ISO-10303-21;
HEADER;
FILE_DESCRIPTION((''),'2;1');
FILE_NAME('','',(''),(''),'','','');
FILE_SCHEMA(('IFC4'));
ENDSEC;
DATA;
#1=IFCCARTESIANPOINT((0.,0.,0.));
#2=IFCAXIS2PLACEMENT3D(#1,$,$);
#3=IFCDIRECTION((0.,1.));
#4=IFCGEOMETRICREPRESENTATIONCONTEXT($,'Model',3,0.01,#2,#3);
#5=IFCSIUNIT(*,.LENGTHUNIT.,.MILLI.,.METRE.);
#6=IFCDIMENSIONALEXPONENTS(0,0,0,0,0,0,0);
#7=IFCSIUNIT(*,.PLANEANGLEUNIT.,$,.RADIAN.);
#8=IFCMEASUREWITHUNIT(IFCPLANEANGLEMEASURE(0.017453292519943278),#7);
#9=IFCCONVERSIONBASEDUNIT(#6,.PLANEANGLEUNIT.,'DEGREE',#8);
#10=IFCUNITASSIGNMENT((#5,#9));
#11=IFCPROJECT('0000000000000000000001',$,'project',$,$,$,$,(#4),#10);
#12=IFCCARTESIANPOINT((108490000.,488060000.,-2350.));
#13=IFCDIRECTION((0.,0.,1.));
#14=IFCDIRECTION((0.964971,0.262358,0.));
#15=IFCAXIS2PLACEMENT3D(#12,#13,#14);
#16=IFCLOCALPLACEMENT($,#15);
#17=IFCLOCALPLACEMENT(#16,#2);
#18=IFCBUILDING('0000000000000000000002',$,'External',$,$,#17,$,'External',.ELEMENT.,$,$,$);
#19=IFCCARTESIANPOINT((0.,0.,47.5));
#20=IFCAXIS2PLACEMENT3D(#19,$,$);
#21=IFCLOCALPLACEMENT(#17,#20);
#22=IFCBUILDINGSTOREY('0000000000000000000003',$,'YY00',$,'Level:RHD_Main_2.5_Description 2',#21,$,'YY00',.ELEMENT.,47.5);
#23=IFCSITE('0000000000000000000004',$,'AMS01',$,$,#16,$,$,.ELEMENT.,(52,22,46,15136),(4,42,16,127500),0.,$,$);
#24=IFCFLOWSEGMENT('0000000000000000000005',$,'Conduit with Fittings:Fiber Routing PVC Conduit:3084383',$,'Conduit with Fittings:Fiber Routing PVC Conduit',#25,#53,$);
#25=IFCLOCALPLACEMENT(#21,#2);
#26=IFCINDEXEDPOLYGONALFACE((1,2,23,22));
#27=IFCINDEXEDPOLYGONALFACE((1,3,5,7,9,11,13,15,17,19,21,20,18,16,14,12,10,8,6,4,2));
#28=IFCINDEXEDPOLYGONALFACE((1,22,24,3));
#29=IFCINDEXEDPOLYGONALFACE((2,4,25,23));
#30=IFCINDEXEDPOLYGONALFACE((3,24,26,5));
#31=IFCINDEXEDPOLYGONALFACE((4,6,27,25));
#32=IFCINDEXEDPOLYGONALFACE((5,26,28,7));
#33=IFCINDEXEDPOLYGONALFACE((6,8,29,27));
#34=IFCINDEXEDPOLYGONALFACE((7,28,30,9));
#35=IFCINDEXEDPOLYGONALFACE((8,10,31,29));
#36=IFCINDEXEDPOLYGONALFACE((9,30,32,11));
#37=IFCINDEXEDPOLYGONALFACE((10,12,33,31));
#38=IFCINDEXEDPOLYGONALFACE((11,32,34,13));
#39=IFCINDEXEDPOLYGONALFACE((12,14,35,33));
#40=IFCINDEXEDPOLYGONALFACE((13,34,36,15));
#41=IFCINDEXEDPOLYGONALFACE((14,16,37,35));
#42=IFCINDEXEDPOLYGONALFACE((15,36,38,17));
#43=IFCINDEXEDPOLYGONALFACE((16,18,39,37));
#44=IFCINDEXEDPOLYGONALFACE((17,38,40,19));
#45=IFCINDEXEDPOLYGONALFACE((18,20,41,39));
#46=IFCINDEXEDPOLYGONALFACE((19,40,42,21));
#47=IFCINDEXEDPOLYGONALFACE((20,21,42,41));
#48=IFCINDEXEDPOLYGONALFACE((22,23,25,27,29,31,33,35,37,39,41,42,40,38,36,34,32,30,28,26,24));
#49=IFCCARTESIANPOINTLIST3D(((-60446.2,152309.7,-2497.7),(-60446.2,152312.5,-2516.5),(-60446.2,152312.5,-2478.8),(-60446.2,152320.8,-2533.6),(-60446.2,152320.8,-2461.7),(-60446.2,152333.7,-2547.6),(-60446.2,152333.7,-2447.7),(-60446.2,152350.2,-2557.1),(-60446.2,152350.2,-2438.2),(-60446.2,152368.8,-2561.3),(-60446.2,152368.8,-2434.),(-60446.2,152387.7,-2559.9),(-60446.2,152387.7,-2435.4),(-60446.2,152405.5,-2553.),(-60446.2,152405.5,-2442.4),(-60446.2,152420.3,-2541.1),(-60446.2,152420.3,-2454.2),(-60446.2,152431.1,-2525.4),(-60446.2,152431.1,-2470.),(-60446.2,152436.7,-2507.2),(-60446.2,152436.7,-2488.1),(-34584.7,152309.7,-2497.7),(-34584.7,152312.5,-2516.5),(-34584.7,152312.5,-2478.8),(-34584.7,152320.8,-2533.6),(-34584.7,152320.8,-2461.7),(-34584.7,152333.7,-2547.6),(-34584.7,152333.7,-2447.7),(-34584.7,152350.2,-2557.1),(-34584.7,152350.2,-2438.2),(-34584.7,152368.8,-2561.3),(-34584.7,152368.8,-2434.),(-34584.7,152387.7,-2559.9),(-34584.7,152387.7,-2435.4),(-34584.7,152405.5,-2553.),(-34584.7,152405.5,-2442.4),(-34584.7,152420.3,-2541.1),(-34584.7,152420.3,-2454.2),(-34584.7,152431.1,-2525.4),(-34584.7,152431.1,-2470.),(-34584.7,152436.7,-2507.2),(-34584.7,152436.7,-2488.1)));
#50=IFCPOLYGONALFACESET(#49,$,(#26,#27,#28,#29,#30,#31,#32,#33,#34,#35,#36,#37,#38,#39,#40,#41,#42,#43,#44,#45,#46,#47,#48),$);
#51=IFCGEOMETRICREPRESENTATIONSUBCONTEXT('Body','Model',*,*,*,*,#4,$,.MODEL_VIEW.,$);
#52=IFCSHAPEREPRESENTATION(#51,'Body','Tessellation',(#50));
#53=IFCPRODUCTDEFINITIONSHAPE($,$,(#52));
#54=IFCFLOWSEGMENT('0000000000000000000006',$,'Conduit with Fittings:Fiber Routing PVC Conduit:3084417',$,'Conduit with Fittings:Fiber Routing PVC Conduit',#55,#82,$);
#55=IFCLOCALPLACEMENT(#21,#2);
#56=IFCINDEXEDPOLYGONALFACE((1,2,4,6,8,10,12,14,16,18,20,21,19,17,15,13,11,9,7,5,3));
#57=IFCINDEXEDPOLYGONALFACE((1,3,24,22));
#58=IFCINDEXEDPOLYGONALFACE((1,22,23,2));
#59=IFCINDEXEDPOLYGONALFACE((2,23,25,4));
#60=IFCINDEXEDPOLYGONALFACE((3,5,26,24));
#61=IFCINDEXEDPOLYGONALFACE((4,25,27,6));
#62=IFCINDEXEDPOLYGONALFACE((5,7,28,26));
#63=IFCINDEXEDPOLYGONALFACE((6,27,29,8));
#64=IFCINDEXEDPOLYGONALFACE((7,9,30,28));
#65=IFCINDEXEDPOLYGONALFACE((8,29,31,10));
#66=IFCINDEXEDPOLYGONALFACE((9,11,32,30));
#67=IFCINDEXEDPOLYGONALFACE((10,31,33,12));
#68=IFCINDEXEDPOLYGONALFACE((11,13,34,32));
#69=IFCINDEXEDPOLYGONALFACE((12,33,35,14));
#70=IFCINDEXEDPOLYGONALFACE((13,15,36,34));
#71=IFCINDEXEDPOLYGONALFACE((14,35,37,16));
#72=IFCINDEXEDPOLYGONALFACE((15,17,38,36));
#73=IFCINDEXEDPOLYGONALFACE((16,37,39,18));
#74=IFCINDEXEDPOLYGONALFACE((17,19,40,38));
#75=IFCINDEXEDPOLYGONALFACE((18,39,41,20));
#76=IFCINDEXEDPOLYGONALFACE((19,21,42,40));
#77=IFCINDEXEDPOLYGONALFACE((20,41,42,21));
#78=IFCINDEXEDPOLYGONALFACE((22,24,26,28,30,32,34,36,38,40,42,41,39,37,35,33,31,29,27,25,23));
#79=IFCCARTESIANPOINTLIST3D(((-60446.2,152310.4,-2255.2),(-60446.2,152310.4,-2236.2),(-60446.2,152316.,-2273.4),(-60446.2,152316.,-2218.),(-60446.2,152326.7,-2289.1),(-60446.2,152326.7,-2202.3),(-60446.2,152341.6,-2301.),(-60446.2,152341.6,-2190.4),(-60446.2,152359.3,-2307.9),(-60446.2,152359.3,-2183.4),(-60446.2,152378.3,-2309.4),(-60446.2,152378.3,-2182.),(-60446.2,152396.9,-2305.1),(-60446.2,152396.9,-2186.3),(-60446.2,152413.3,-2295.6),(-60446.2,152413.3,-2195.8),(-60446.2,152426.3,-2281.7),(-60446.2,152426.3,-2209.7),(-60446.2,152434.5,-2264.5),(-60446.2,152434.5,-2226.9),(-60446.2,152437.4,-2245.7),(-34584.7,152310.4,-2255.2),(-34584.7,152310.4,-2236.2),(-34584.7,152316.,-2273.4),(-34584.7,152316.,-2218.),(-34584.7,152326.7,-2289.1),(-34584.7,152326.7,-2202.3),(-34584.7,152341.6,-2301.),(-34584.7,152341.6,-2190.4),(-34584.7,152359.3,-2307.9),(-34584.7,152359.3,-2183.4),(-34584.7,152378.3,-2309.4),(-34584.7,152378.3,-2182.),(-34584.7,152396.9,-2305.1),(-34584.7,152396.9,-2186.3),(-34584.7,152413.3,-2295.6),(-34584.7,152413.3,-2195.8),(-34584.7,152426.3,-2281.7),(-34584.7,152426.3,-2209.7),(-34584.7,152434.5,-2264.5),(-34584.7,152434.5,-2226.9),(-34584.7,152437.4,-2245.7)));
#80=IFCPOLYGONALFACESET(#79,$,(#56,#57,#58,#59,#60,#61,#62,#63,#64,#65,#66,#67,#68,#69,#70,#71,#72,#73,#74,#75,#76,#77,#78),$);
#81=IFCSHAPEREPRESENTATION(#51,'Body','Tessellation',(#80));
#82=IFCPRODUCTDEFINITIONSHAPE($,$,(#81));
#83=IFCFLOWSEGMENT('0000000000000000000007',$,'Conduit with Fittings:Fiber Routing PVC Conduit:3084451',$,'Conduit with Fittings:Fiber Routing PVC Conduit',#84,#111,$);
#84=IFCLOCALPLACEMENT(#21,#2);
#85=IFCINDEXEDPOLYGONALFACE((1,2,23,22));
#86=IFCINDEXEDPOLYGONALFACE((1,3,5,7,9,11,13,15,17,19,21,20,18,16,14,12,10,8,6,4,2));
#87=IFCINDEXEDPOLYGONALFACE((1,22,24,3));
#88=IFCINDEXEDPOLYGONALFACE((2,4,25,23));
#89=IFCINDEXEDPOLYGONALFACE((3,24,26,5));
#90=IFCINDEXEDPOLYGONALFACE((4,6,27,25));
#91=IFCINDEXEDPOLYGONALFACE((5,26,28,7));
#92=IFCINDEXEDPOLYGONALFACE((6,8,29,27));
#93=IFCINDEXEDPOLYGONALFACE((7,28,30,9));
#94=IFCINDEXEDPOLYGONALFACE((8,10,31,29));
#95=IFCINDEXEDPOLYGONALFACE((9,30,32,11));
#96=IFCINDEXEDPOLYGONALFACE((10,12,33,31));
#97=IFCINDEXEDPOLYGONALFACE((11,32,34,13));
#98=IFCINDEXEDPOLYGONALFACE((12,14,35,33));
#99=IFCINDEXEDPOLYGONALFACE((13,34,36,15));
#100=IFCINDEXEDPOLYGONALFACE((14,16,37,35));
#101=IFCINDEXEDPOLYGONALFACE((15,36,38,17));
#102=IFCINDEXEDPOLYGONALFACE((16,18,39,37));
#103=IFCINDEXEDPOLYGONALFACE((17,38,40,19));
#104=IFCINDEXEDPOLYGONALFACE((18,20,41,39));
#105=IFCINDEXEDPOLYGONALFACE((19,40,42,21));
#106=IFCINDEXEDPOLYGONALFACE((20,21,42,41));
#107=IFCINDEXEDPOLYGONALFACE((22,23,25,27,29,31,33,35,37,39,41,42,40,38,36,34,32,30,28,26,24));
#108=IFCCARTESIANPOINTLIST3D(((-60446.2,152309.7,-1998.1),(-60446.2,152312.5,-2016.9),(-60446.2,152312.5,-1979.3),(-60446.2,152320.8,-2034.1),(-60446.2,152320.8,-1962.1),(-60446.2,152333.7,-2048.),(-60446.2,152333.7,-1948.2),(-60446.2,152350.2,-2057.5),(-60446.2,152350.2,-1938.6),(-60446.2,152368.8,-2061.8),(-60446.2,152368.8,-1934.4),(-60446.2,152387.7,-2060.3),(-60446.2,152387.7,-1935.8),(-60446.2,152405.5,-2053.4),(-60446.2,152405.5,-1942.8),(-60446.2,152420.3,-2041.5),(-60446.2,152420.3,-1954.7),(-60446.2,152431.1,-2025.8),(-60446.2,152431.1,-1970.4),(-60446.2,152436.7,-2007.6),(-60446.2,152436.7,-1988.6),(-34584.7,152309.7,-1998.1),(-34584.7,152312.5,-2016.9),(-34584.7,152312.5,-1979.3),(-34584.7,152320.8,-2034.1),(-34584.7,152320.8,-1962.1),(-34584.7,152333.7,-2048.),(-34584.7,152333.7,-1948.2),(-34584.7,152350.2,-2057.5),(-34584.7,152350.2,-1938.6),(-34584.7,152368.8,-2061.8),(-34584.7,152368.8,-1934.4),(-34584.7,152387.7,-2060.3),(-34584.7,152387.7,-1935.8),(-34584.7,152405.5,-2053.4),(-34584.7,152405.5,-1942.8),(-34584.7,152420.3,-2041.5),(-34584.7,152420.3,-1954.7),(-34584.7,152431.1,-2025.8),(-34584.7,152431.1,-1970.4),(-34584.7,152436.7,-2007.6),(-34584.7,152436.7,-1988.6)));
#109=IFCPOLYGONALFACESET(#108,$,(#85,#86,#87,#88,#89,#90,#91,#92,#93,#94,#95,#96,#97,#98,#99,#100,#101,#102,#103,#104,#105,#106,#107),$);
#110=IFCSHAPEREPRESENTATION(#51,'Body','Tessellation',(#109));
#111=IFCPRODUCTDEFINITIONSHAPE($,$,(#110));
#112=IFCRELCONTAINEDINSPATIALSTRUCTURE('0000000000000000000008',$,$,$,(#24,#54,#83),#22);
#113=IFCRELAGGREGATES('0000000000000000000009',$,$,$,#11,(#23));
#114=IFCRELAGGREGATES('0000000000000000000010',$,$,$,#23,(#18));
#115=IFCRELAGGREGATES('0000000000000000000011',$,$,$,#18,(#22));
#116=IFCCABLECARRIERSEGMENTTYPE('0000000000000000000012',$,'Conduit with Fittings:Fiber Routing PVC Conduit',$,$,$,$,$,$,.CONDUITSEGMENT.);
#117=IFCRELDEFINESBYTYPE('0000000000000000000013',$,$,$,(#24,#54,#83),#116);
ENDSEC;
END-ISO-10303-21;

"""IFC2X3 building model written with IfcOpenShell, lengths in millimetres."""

from ifc_helpers import new_model, entity, si_unit, converted_unit, direction, frame, frame_2d, origin, origin_2d_with_axis, place, context, subcontext, project, spatial, circle, extrude, type_object, element, save


model = new_model("IFC2X3")

# Units and contexts
model_context = context("Model", 3, precision=0.01, world=origin(), true_north=direction((0.0, 1.0)))
body_context = subcontext(model_context, "Body", "Model", "MODEL_VIEW")
ifc_project = project(units=[si_unit("LENGTHUNIT", "METRE", prefix="MILLI"), converted_unit("PLANEANGLEUNIT", "DEGREE", entity("IfcPlaneAngleMeasure", 0.017453292519943278), si_unit("PLANEANGLEUNIT", "RADIAN"), dimensions=[0, 0, 0, 0, 0, 0, 0])], contexts=[model_context])

# Site, building, storey
site_placement = place(None, frame((108490000.0, 488060000.0, -2350.0), z_axis=(0.0, 0.0, 1.0), x_axis=(0.964971, 0.262358, 0.0)))
site = spatial("IfcSite", under=ifc_project, at=site_placement, Name="AMS01", CompositionType="ELEMENT", RefLatitude=(52, 22, 46, 15136), RefLongitude=(4, 42, 16, 127500), RefElevation=0.0)
building_placement = place(site_placement, origin())
building = spatial("IfcBuilding", under=site, at=building_placement, Name="External", LongName="External", CompositionType="ELEMENT")
storey_placement = place(building_placement, frame((0.0, 0.0, 47.5)))
storey = spatial("IfcBuildingStorey", under=building, at=storey_placement, Name="YY00", ObjectType="Level:RHD_Main_2.5_Description 2", LongName="YY00", CompositionType="ELEMENT", Elevation=47.5)

# Flow segments
cable_carrier_segment_type = type_object("IfcCableCarrierSegmentType", Name="Conduit with Fittings:Fiber Routing PVC Conduit", PredefinedType="CONDUITSEGMENT")
flow_segment_1_placement = place(storey_placement, origin())
element("IfcFlowSegment", 1, at=flow_segment_1_placement, inside=storey, type_object=cable_carrier_segment_type, Name="Conduit with Fittings:Fiber Routing PVC Conduit:3084383", ObjectType="Conduit with Fittings:Fiber Routing PVC Conduit", context=body_context, shape_type="SweptSolid", body=[
    extrude(circle(Radius=63.9, at=origin_2d_with_axis()), frame((-60446.2, 152373.5, -2497.7), z_axis=(1.0, 0.0, 0.0), x_axis=(0.0, -1.0, 0.0)), (0.0, 0.0, 1.0), 25861.6),
])
flow_segment_2_placement = place(storey_placement, origin())
element("IfcFlowSegment", 2, at=flow_segment_2_placement, inside=storey, type_object=cable_carrier_segment_type, Name="Conduit with Fittings:Fiber Routing PVC Conduit:3084417", ObjectType="Conduit with Fittings:Fiber Routing PVC Conduit", context=body_context, shape_type="SweptSolid", body=[
    extrude(circle(Radius=63.9, at=frame_2d((0.0, 0.0), x_axis=(1.0, 0.0))), frame((-60446.2, 152373.5, -2245.7), z_axis=(1.0, 0.0, 0.0), x_axis=(0.0, 1.0, 0.0)), (0.0, 0.0, 1.0), 25861.6),
])
flow_segment_3_placement = place(storey_placement, origin())
element("IfcFlowSegment", 3, at=flow_segment_3_placement, inside=storey, type_object=cable_carrier_segment_type, Name="Conduit with Fittings:Fiber Routing PVC Conduit:3084451", ObjectType="Conduit with Fittings:Fiber Routing PVC Conduit", context=body_context, shape_type="SweptSolid", body=[
    extrude(circle(Radius=63.9, at=origin_2d_with_axis()), frame((-60446.2, 152373.5, -1998.1), z_axis=(1.0, 0.0, 0.0), x_axis=(0.0, -1.0, 0.0)), (0.0, 0.0, 1.0), 25861.6),
])

save(model, "model.ifc")
